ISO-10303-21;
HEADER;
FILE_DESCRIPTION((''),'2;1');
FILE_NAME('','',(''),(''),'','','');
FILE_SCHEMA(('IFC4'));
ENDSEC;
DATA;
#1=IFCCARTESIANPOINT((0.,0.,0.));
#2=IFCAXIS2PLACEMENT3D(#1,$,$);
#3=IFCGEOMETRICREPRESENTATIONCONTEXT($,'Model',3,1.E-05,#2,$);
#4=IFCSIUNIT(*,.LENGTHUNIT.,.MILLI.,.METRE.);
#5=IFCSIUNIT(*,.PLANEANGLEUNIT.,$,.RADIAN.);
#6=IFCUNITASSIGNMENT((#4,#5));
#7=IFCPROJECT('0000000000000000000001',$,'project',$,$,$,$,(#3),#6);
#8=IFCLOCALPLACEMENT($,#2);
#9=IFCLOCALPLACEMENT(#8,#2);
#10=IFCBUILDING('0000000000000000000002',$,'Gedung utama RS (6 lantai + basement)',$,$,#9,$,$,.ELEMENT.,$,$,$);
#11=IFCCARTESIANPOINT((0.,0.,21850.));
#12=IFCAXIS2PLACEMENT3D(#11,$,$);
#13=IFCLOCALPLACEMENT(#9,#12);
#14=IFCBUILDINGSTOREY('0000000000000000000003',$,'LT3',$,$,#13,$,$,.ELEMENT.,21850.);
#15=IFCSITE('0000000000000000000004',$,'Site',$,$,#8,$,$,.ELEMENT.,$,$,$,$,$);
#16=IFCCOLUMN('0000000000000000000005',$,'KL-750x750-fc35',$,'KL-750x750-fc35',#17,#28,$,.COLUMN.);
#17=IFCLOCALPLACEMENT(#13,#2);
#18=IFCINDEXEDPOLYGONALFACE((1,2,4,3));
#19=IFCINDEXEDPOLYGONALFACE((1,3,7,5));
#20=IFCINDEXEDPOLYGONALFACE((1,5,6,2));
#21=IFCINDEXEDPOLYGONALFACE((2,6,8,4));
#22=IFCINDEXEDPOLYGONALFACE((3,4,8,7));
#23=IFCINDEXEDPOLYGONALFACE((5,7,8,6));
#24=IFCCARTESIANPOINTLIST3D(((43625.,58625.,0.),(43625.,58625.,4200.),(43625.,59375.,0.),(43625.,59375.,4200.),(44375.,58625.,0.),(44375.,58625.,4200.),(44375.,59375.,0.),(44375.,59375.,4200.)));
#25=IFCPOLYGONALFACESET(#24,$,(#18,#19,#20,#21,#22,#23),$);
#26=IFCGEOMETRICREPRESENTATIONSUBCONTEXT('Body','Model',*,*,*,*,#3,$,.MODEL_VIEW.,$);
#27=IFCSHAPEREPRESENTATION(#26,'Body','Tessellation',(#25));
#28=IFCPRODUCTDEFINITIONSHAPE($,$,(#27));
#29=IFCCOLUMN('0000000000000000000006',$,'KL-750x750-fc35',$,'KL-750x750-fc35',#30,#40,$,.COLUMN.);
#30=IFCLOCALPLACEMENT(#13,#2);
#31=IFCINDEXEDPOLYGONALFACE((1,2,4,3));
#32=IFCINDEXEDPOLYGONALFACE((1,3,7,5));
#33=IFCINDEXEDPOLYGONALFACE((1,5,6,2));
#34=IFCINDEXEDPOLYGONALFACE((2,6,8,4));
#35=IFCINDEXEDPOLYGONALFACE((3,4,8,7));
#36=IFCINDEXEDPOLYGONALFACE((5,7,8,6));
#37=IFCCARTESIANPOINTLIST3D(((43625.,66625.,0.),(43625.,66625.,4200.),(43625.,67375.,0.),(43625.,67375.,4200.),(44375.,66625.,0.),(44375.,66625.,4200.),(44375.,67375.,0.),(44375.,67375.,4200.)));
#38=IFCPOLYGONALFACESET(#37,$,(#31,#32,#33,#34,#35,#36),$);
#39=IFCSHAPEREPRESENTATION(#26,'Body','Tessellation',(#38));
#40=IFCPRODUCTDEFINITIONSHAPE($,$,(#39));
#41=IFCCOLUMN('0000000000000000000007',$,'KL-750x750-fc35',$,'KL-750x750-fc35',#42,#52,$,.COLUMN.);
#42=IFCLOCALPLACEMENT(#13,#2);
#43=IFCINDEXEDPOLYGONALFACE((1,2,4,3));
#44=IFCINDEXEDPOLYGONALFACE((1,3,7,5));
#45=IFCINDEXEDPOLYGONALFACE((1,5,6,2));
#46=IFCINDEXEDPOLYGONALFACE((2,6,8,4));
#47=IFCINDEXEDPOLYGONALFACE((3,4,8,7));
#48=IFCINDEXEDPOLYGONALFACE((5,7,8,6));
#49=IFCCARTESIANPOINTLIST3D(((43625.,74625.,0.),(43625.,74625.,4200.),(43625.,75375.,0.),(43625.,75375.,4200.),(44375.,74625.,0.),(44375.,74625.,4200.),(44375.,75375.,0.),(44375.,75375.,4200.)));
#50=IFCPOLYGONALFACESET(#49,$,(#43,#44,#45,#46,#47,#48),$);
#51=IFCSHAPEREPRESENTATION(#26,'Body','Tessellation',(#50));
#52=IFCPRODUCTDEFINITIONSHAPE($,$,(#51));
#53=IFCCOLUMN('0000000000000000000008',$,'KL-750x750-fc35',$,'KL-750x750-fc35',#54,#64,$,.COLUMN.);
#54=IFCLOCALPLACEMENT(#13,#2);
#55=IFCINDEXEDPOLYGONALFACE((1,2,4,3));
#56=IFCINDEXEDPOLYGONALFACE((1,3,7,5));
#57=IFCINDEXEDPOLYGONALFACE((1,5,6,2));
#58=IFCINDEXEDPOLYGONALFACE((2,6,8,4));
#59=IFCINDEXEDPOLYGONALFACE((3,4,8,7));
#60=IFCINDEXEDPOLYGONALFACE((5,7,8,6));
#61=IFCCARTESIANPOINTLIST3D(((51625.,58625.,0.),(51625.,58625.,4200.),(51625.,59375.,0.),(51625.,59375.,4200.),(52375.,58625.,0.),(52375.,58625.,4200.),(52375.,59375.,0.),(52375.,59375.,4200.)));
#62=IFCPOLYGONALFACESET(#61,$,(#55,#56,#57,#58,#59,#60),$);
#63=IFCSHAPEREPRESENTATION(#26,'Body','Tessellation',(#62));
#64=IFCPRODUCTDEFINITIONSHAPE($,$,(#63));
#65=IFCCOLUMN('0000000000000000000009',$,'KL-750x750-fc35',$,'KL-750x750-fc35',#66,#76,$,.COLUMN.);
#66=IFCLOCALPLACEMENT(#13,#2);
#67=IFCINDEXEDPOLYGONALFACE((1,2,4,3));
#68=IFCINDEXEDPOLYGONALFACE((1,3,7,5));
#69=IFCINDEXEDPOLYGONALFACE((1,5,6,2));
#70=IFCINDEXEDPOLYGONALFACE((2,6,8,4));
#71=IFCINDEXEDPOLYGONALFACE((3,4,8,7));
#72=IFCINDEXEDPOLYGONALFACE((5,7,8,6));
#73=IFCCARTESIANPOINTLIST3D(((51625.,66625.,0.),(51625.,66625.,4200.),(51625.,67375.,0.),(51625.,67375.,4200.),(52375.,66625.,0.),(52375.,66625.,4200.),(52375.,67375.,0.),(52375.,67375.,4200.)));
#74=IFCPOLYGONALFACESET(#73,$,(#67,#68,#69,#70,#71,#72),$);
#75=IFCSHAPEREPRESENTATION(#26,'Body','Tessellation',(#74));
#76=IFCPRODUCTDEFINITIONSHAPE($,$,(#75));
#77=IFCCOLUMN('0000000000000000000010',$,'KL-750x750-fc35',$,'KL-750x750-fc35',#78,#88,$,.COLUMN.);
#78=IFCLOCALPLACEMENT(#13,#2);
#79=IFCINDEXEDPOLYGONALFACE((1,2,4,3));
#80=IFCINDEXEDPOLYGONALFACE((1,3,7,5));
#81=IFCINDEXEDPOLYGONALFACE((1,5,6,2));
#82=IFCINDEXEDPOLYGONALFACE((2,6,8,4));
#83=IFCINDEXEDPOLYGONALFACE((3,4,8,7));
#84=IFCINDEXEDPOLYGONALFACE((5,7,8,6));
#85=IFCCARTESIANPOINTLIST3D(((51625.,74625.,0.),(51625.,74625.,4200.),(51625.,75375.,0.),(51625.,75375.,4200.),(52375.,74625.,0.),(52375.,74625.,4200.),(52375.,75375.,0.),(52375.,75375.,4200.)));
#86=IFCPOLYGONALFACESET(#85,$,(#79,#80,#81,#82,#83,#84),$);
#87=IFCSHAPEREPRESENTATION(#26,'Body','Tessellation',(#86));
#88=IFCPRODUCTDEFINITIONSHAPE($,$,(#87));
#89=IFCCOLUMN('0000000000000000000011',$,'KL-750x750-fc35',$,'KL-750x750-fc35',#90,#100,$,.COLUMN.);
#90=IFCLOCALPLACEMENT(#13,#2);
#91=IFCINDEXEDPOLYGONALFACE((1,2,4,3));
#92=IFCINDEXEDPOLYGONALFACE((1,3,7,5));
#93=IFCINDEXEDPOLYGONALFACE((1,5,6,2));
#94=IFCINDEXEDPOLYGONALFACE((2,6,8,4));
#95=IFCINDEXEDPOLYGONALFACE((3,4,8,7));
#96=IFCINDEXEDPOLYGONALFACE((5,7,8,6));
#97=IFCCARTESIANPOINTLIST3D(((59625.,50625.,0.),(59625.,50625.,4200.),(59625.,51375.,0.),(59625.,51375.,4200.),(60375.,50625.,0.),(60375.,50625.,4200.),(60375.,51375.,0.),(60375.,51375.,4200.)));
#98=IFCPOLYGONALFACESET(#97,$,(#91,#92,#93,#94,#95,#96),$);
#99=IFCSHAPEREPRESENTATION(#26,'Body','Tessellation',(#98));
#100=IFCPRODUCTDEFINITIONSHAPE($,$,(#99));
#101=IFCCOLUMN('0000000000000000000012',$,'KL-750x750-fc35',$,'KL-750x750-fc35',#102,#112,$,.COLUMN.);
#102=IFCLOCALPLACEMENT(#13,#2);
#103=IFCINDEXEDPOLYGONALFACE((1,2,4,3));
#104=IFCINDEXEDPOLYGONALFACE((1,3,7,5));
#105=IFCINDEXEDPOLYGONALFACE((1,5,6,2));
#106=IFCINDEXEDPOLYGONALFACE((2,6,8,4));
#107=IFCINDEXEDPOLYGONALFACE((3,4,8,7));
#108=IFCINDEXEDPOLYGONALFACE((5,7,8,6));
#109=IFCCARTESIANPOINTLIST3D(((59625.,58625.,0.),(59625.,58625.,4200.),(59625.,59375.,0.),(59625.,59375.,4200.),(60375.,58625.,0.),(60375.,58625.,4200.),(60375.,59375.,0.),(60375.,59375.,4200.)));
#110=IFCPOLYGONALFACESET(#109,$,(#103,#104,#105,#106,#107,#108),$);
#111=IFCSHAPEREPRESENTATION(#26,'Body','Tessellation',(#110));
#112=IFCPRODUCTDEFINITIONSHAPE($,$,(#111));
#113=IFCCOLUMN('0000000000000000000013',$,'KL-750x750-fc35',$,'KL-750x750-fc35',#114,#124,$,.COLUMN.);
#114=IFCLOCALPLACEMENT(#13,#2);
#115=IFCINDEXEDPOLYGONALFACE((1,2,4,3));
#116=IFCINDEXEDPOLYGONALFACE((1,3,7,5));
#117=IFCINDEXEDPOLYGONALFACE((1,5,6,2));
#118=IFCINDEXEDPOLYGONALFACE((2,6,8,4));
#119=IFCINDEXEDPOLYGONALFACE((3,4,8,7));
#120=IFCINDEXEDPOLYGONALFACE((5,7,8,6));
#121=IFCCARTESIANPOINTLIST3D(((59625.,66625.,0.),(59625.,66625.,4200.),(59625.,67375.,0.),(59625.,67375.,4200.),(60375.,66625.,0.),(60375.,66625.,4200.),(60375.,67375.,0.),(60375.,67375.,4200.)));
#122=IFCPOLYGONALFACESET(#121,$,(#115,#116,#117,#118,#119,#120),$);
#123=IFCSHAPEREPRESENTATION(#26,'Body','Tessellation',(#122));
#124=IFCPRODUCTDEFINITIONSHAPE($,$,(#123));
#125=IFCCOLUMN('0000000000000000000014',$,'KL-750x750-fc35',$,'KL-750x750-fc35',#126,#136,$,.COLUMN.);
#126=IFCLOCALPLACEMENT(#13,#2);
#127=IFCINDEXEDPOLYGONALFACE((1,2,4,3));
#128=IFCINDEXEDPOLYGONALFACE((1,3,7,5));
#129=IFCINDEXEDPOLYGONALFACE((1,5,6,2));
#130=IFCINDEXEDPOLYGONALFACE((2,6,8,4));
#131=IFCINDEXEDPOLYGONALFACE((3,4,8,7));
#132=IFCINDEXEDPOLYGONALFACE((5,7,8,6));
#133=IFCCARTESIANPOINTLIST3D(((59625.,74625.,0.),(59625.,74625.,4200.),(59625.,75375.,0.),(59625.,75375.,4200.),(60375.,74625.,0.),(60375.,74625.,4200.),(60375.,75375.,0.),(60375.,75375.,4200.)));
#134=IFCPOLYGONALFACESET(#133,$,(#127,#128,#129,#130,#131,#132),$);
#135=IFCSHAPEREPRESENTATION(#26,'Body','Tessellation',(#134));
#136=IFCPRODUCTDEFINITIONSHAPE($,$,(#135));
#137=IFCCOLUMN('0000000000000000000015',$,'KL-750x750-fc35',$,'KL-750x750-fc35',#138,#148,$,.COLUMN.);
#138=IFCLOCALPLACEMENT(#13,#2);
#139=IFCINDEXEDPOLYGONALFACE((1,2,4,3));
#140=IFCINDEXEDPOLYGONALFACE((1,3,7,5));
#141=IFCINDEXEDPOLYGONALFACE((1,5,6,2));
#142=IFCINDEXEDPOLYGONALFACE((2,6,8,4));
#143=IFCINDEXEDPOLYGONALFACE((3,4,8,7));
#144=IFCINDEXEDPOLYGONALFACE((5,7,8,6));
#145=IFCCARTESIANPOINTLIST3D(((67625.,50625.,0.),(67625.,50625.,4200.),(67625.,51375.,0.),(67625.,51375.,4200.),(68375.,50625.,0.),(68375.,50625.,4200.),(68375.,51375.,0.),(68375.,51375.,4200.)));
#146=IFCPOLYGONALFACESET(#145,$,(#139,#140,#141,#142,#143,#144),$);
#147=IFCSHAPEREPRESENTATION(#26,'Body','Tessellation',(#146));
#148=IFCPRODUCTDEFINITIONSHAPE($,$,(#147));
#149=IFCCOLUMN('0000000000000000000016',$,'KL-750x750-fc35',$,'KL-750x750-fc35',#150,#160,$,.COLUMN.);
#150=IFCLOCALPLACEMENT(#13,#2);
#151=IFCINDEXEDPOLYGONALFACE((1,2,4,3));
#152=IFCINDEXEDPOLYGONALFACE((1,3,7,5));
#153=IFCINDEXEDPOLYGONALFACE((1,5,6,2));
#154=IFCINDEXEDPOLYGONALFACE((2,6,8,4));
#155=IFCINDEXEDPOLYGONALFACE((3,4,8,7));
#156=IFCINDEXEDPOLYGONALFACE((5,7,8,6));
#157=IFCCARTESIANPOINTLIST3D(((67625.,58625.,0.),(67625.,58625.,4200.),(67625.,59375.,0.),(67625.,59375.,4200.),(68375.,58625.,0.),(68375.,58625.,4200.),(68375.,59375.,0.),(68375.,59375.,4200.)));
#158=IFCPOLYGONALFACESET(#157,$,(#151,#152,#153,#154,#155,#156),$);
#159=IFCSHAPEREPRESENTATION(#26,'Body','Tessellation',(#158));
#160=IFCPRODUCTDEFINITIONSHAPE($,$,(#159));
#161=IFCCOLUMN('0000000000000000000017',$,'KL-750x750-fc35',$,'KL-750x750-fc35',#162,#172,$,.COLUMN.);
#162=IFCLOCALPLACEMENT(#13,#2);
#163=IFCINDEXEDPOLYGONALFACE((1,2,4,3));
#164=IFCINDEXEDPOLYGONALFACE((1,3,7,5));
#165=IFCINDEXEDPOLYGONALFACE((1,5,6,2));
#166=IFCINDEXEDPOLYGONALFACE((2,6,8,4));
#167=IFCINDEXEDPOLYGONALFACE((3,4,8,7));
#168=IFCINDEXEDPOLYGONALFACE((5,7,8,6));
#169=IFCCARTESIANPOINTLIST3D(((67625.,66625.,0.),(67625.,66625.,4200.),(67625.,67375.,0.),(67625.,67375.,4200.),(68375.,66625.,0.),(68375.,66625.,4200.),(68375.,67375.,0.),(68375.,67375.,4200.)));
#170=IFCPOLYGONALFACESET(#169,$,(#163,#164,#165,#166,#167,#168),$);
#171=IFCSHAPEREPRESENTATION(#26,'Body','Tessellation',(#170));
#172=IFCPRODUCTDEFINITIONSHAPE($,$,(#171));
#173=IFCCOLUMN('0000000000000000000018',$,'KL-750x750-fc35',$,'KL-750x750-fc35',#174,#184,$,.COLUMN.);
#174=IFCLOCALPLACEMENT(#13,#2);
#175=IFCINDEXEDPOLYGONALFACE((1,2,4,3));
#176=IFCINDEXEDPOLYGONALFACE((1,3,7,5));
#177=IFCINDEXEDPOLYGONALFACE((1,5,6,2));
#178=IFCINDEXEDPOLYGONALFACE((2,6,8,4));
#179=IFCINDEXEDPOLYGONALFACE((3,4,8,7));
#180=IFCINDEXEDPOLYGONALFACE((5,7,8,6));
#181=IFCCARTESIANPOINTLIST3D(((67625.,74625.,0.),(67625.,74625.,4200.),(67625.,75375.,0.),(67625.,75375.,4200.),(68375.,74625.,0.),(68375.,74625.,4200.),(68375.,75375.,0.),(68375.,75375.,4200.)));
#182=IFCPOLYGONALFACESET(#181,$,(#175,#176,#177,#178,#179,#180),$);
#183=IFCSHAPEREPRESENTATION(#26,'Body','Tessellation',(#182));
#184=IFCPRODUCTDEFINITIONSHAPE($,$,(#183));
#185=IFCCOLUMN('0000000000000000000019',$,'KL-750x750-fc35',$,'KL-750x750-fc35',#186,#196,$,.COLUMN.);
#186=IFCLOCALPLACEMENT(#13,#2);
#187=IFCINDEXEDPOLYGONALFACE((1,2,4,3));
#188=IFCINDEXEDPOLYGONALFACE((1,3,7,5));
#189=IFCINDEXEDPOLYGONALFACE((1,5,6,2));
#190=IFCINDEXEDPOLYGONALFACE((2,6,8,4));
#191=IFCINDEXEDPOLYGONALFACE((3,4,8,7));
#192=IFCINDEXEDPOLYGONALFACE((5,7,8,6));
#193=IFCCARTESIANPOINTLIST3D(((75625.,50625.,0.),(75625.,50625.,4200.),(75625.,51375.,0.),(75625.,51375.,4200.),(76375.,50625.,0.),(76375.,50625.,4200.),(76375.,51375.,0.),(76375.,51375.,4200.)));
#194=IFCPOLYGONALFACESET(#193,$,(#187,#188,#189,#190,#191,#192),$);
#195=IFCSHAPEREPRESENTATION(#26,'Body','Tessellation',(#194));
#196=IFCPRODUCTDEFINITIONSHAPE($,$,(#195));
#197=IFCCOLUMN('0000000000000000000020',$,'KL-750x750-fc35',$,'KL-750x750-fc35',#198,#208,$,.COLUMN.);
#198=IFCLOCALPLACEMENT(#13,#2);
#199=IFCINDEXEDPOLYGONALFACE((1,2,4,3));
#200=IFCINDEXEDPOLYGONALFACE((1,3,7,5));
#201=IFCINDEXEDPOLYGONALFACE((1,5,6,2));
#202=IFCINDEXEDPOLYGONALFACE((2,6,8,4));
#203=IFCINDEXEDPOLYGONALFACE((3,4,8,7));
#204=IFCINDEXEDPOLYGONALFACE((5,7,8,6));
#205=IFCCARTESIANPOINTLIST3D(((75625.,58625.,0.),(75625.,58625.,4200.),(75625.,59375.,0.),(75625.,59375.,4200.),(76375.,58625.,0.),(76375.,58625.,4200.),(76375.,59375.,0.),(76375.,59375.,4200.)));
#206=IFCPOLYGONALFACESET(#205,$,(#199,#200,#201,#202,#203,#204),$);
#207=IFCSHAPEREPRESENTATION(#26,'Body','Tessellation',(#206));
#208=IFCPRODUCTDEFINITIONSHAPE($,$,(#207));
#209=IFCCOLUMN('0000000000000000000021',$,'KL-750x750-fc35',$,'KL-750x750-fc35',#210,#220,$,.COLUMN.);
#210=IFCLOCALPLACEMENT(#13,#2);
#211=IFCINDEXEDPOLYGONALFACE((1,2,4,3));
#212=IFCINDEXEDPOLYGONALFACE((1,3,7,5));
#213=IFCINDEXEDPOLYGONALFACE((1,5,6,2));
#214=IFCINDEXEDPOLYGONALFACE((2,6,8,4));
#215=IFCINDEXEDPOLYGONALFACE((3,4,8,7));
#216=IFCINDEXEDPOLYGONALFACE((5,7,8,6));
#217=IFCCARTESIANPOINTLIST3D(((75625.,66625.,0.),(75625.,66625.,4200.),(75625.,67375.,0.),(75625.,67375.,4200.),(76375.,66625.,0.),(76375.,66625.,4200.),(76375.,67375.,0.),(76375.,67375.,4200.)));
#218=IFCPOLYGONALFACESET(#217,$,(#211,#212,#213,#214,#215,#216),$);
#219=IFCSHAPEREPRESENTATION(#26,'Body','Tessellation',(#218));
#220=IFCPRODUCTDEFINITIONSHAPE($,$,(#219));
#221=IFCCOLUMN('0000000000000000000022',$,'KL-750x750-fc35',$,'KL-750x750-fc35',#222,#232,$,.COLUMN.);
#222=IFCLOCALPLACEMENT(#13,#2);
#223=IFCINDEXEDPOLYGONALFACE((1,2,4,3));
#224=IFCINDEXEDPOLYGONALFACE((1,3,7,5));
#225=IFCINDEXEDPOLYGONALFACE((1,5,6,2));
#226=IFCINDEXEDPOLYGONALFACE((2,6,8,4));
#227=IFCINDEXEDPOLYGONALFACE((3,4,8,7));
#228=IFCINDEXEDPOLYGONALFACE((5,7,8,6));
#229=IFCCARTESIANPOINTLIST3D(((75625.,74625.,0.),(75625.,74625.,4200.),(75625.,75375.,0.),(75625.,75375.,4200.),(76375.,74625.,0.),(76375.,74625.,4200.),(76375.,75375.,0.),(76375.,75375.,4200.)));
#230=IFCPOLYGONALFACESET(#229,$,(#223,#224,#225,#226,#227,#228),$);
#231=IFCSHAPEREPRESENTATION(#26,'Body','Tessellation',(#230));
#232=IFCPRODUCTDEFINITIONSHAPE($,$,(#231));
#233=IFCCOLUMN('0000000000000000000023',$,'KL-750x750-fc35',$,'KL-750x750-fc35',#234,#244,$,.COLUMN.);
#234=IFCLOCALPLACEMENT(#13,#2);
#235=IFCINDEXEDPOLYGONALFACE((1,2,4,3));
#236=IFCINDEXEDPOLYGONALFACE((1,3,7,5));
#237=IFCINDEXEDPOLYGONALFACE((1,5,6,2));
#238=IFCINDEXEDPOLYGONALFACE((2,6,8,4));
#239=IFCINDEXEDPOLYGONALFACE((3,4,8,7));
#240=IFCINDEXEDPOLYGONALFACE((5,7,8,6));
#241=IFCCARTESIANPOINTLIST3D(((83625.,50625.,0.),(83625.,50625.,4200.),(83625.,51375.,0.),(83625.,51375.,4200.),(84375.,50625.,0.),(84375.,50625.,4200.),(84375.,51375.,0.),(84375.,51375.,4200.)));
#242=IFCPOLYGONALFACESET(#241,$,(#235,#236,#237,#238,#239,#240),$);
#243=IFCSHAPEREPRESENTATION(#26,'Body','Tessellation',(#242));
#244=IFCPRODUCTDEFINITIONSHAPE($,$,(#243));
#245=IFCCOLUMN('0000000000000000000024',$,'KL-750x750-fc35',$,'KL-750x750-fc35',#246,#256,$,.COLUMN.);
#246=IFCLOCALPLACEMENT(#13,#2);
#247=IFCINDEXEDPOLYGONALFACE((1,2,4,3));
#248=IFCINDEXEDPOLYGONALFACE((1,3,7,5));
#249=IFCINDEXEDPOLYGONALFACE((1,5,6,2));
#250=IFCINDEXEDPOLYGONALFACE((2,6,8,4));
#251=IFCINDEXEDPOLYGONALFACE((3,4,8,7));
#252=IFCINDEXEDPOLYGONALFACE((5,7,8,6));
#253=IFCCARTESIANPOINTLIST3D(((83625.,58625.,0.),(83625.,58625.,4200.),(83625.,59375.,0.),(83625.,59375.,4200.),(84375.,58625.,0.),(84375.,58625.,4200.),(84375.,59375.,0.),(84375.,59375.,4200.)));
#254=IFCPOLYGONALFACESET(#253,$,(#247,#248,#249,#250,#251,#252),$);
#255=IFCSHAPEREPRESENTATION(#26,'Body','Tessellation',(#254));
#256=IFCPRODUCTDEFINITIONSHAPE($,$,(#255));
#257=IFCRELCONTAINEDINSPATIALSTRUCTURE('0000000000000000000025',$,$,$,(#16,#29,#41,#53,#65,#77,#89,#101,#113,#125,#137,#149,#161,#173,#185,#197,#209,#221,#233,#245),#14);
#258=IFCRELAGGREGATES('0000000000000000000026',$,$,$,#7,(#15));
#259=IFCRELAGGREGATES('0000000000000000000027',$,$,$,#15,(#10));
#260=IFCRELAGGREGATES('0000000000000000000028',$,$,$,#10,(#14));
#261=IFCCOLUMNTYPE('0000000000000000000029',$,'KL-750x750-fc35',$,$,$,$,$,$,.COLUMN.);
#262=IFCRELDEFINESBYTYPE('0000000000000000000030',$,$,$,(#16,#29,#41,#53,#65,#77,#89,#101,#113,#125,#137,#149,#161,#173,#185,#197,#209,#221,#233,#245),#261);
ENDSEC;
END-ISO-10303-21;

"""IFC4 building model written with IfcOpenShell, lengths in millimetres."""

from ifc_helpers import new_model, si_unit, frame, origin, origin_2d, place, context, subcontext, project, spatial, rectangle, extrude, material_profile, profile_set, profile_usage, type_object, element, save


model = new_model("IFC4")

# Units and contexts
model_context = context("Model", 3, precision=1e-05, world=origin())
body_context = subcontext(model_context, "Body", "Model", "MODEL_VIEW")
ifc_project = project(units=[si_unit("LENGTHUNIT", "METRE", prefix="MILLI"), si_unit("PLANEANGLEUNIT", "RADIAN")], contexts=[model_context])

# Site, building, storey
site_placement = place(None, origin())
site = spatial("IfcSite", under=ifc_project, at=site_placement, Name="Site", CompositionType="ELEMENT")
building_placement = place(site_placement, origin())
building = spatial("IfcBuilding", under=site, at=building_placement, Name="Gedung utama RS (6 lantai + basement)", CompositionType="ELEMENT")
storey_placement = place(building_placement, frame((0.0, 0.0, 21850.0)))
storey = spatial("IfcBuildingStorey", under=building, at=storey_placement, Name="LT3", CompositionType="ELEMENT", Elevation=21850.0)

# Columns
ifc_material_profile = material_profile(None, rectangle(XDim=750.0, YDim=750.0, at=origin_2d()), Name="KL-750x750-fc35")
ifc_profile_set = profile_set([ifc_material_profile], Name="KL-750x750-fc35")
ifc_profile_usage = profile_usage(ifc_profile_set, cardinal=5)
column_type = type_object("IfcColumnType", Name="KL-750x750-fc35", PredefinedType="COLUMN", material=ifc_profile_set)
for number, where, z_axis, x_axis, name in (
    (1, (44000.0, 59000.0, 0.0), (0.0, 0.0, 1.0), (1.0, 0.0, 0.0), "KL-750x750-fc35"),
    (2, (44000.0, 67000.0, 0.0), (0.0, 0.0, 1.0), (1.0, 0.0, 0.0), "KL-750x750-fc35"),
    (3, (44000.0, 75000.0, 0.0), (0.0, 0.0, 1.0), (1.0, 0.0, 0.0), "KL-750x750-fc35"),
    (4, (52000.0, 59000.0, 0.0), (0.0, 0.0, 1.0), (1.0, 0.0, 0.0), "KL-750x750-fc35"),
    (5, (52000.0, 67000.0, 0.0), (0.0, 0.0, 1.0), (1.0, 0.0, 0.0), "KL-750x750-fc35"),
    (6, (52000.0, 75000.0, 0.0), (0.0, 0.0, 1.0), (1.0, 0.0, 0.0), "KL-750x750-fc35"),
    (7, (60000.0, 51000.0, 0.0), (0.0, 0.0, 1.0), (1.0, 0.0, 0.0), "KL-750x750-fc35"),
    (8, (60000.0, 59000.0, 0.0), (0.0, 0.0, 1.0), (1.0, 0.0, 0.0), "KL-750x750-fc35"),
    (9, (60000.0, 67000.0, 0.0), (0.0, 0.0, 1.0), (1.0, 0.0, 0.0), "KL-750x750-fc35"),
    (10, (60000.0, 75000.0, 0.0), (0.0, 0.0, 1.0), (1.0, 0.0, 0.0), "KL-750x750-fc35"),
    (11, (68000.0, 51000.0, 0.0), (0.0, 0.0, 1.0), (1.0, 0.0, 0.0), "KL-750x750-fc35"),
    (12, (68000.0, 59000.0, 0.0), (0.0, 0.0, 1.0), (1.0, 0.0, 0.0), "KL-750x750-fc35"),
    (13, (68000.0, 67000.0, 0.0), (0.0, 0.0, 1.0), (1.0, 0.0, 0.0), "KL-750x750-fc35"),
    (14, (68000.0, 75000.0, 0.0), (0.0, 0.0, 1.0), (1.0, 0.0, 0.0), "KL-750x750-fc35"),
    (15, (76000.0, 51000.0, 0.0), (0.0, 0.0, 1.0), (1.0, 0.0, 0.0), "KL-750x750-fc35"),
    (16, (76000.0, 59000.0, 0.0), (0.0, 0.0, 1.0), (1.0, 0.0, 0.0), "KL-750x750-fc35"),
    (17, (76000.0, 67000.0, 0.0), (0.0, 0.0, 1.0), (1.0, 0.0, 0.0), "KL-750x750-fc35"),
    (18, (76000.0, 75000.0, 0.0), (0.0, 0.0, 1.0), (1.0, 0.0, 0.0), "KL-750x750-fc35"),
    (19, (84000.0, 51000.0, 0.0), (0.0, 0.0, 1.0), (1.0, 0.0, 0.0), "KL-750x750-fc35"),
    (20, (84000.0, 59000.0, 0.0), (0.0, 0.0, 1.0), (1.0, 0.0, 0.0), "KL-750x750-fc35"),
):
    element("IfcColumn", number, at=place(storey_placement, frame(where, z_axis=z_axis, x_axis=x_axis)), inside=storey, type_object=column_type, material=ifc_profile_usage, Name=name, ObjectType="KL-750x750-fc35", PredefinedType="COLUMN", context=body_context, shape_type="SweptSolid", body=[
        extrude(rectangle(XDim=750.0, YDim=750.0, at=origin_2d()), origin(), (0.0, 0.0, 1.0), 4200.0),
    ])

save(model, "model.ifc")
